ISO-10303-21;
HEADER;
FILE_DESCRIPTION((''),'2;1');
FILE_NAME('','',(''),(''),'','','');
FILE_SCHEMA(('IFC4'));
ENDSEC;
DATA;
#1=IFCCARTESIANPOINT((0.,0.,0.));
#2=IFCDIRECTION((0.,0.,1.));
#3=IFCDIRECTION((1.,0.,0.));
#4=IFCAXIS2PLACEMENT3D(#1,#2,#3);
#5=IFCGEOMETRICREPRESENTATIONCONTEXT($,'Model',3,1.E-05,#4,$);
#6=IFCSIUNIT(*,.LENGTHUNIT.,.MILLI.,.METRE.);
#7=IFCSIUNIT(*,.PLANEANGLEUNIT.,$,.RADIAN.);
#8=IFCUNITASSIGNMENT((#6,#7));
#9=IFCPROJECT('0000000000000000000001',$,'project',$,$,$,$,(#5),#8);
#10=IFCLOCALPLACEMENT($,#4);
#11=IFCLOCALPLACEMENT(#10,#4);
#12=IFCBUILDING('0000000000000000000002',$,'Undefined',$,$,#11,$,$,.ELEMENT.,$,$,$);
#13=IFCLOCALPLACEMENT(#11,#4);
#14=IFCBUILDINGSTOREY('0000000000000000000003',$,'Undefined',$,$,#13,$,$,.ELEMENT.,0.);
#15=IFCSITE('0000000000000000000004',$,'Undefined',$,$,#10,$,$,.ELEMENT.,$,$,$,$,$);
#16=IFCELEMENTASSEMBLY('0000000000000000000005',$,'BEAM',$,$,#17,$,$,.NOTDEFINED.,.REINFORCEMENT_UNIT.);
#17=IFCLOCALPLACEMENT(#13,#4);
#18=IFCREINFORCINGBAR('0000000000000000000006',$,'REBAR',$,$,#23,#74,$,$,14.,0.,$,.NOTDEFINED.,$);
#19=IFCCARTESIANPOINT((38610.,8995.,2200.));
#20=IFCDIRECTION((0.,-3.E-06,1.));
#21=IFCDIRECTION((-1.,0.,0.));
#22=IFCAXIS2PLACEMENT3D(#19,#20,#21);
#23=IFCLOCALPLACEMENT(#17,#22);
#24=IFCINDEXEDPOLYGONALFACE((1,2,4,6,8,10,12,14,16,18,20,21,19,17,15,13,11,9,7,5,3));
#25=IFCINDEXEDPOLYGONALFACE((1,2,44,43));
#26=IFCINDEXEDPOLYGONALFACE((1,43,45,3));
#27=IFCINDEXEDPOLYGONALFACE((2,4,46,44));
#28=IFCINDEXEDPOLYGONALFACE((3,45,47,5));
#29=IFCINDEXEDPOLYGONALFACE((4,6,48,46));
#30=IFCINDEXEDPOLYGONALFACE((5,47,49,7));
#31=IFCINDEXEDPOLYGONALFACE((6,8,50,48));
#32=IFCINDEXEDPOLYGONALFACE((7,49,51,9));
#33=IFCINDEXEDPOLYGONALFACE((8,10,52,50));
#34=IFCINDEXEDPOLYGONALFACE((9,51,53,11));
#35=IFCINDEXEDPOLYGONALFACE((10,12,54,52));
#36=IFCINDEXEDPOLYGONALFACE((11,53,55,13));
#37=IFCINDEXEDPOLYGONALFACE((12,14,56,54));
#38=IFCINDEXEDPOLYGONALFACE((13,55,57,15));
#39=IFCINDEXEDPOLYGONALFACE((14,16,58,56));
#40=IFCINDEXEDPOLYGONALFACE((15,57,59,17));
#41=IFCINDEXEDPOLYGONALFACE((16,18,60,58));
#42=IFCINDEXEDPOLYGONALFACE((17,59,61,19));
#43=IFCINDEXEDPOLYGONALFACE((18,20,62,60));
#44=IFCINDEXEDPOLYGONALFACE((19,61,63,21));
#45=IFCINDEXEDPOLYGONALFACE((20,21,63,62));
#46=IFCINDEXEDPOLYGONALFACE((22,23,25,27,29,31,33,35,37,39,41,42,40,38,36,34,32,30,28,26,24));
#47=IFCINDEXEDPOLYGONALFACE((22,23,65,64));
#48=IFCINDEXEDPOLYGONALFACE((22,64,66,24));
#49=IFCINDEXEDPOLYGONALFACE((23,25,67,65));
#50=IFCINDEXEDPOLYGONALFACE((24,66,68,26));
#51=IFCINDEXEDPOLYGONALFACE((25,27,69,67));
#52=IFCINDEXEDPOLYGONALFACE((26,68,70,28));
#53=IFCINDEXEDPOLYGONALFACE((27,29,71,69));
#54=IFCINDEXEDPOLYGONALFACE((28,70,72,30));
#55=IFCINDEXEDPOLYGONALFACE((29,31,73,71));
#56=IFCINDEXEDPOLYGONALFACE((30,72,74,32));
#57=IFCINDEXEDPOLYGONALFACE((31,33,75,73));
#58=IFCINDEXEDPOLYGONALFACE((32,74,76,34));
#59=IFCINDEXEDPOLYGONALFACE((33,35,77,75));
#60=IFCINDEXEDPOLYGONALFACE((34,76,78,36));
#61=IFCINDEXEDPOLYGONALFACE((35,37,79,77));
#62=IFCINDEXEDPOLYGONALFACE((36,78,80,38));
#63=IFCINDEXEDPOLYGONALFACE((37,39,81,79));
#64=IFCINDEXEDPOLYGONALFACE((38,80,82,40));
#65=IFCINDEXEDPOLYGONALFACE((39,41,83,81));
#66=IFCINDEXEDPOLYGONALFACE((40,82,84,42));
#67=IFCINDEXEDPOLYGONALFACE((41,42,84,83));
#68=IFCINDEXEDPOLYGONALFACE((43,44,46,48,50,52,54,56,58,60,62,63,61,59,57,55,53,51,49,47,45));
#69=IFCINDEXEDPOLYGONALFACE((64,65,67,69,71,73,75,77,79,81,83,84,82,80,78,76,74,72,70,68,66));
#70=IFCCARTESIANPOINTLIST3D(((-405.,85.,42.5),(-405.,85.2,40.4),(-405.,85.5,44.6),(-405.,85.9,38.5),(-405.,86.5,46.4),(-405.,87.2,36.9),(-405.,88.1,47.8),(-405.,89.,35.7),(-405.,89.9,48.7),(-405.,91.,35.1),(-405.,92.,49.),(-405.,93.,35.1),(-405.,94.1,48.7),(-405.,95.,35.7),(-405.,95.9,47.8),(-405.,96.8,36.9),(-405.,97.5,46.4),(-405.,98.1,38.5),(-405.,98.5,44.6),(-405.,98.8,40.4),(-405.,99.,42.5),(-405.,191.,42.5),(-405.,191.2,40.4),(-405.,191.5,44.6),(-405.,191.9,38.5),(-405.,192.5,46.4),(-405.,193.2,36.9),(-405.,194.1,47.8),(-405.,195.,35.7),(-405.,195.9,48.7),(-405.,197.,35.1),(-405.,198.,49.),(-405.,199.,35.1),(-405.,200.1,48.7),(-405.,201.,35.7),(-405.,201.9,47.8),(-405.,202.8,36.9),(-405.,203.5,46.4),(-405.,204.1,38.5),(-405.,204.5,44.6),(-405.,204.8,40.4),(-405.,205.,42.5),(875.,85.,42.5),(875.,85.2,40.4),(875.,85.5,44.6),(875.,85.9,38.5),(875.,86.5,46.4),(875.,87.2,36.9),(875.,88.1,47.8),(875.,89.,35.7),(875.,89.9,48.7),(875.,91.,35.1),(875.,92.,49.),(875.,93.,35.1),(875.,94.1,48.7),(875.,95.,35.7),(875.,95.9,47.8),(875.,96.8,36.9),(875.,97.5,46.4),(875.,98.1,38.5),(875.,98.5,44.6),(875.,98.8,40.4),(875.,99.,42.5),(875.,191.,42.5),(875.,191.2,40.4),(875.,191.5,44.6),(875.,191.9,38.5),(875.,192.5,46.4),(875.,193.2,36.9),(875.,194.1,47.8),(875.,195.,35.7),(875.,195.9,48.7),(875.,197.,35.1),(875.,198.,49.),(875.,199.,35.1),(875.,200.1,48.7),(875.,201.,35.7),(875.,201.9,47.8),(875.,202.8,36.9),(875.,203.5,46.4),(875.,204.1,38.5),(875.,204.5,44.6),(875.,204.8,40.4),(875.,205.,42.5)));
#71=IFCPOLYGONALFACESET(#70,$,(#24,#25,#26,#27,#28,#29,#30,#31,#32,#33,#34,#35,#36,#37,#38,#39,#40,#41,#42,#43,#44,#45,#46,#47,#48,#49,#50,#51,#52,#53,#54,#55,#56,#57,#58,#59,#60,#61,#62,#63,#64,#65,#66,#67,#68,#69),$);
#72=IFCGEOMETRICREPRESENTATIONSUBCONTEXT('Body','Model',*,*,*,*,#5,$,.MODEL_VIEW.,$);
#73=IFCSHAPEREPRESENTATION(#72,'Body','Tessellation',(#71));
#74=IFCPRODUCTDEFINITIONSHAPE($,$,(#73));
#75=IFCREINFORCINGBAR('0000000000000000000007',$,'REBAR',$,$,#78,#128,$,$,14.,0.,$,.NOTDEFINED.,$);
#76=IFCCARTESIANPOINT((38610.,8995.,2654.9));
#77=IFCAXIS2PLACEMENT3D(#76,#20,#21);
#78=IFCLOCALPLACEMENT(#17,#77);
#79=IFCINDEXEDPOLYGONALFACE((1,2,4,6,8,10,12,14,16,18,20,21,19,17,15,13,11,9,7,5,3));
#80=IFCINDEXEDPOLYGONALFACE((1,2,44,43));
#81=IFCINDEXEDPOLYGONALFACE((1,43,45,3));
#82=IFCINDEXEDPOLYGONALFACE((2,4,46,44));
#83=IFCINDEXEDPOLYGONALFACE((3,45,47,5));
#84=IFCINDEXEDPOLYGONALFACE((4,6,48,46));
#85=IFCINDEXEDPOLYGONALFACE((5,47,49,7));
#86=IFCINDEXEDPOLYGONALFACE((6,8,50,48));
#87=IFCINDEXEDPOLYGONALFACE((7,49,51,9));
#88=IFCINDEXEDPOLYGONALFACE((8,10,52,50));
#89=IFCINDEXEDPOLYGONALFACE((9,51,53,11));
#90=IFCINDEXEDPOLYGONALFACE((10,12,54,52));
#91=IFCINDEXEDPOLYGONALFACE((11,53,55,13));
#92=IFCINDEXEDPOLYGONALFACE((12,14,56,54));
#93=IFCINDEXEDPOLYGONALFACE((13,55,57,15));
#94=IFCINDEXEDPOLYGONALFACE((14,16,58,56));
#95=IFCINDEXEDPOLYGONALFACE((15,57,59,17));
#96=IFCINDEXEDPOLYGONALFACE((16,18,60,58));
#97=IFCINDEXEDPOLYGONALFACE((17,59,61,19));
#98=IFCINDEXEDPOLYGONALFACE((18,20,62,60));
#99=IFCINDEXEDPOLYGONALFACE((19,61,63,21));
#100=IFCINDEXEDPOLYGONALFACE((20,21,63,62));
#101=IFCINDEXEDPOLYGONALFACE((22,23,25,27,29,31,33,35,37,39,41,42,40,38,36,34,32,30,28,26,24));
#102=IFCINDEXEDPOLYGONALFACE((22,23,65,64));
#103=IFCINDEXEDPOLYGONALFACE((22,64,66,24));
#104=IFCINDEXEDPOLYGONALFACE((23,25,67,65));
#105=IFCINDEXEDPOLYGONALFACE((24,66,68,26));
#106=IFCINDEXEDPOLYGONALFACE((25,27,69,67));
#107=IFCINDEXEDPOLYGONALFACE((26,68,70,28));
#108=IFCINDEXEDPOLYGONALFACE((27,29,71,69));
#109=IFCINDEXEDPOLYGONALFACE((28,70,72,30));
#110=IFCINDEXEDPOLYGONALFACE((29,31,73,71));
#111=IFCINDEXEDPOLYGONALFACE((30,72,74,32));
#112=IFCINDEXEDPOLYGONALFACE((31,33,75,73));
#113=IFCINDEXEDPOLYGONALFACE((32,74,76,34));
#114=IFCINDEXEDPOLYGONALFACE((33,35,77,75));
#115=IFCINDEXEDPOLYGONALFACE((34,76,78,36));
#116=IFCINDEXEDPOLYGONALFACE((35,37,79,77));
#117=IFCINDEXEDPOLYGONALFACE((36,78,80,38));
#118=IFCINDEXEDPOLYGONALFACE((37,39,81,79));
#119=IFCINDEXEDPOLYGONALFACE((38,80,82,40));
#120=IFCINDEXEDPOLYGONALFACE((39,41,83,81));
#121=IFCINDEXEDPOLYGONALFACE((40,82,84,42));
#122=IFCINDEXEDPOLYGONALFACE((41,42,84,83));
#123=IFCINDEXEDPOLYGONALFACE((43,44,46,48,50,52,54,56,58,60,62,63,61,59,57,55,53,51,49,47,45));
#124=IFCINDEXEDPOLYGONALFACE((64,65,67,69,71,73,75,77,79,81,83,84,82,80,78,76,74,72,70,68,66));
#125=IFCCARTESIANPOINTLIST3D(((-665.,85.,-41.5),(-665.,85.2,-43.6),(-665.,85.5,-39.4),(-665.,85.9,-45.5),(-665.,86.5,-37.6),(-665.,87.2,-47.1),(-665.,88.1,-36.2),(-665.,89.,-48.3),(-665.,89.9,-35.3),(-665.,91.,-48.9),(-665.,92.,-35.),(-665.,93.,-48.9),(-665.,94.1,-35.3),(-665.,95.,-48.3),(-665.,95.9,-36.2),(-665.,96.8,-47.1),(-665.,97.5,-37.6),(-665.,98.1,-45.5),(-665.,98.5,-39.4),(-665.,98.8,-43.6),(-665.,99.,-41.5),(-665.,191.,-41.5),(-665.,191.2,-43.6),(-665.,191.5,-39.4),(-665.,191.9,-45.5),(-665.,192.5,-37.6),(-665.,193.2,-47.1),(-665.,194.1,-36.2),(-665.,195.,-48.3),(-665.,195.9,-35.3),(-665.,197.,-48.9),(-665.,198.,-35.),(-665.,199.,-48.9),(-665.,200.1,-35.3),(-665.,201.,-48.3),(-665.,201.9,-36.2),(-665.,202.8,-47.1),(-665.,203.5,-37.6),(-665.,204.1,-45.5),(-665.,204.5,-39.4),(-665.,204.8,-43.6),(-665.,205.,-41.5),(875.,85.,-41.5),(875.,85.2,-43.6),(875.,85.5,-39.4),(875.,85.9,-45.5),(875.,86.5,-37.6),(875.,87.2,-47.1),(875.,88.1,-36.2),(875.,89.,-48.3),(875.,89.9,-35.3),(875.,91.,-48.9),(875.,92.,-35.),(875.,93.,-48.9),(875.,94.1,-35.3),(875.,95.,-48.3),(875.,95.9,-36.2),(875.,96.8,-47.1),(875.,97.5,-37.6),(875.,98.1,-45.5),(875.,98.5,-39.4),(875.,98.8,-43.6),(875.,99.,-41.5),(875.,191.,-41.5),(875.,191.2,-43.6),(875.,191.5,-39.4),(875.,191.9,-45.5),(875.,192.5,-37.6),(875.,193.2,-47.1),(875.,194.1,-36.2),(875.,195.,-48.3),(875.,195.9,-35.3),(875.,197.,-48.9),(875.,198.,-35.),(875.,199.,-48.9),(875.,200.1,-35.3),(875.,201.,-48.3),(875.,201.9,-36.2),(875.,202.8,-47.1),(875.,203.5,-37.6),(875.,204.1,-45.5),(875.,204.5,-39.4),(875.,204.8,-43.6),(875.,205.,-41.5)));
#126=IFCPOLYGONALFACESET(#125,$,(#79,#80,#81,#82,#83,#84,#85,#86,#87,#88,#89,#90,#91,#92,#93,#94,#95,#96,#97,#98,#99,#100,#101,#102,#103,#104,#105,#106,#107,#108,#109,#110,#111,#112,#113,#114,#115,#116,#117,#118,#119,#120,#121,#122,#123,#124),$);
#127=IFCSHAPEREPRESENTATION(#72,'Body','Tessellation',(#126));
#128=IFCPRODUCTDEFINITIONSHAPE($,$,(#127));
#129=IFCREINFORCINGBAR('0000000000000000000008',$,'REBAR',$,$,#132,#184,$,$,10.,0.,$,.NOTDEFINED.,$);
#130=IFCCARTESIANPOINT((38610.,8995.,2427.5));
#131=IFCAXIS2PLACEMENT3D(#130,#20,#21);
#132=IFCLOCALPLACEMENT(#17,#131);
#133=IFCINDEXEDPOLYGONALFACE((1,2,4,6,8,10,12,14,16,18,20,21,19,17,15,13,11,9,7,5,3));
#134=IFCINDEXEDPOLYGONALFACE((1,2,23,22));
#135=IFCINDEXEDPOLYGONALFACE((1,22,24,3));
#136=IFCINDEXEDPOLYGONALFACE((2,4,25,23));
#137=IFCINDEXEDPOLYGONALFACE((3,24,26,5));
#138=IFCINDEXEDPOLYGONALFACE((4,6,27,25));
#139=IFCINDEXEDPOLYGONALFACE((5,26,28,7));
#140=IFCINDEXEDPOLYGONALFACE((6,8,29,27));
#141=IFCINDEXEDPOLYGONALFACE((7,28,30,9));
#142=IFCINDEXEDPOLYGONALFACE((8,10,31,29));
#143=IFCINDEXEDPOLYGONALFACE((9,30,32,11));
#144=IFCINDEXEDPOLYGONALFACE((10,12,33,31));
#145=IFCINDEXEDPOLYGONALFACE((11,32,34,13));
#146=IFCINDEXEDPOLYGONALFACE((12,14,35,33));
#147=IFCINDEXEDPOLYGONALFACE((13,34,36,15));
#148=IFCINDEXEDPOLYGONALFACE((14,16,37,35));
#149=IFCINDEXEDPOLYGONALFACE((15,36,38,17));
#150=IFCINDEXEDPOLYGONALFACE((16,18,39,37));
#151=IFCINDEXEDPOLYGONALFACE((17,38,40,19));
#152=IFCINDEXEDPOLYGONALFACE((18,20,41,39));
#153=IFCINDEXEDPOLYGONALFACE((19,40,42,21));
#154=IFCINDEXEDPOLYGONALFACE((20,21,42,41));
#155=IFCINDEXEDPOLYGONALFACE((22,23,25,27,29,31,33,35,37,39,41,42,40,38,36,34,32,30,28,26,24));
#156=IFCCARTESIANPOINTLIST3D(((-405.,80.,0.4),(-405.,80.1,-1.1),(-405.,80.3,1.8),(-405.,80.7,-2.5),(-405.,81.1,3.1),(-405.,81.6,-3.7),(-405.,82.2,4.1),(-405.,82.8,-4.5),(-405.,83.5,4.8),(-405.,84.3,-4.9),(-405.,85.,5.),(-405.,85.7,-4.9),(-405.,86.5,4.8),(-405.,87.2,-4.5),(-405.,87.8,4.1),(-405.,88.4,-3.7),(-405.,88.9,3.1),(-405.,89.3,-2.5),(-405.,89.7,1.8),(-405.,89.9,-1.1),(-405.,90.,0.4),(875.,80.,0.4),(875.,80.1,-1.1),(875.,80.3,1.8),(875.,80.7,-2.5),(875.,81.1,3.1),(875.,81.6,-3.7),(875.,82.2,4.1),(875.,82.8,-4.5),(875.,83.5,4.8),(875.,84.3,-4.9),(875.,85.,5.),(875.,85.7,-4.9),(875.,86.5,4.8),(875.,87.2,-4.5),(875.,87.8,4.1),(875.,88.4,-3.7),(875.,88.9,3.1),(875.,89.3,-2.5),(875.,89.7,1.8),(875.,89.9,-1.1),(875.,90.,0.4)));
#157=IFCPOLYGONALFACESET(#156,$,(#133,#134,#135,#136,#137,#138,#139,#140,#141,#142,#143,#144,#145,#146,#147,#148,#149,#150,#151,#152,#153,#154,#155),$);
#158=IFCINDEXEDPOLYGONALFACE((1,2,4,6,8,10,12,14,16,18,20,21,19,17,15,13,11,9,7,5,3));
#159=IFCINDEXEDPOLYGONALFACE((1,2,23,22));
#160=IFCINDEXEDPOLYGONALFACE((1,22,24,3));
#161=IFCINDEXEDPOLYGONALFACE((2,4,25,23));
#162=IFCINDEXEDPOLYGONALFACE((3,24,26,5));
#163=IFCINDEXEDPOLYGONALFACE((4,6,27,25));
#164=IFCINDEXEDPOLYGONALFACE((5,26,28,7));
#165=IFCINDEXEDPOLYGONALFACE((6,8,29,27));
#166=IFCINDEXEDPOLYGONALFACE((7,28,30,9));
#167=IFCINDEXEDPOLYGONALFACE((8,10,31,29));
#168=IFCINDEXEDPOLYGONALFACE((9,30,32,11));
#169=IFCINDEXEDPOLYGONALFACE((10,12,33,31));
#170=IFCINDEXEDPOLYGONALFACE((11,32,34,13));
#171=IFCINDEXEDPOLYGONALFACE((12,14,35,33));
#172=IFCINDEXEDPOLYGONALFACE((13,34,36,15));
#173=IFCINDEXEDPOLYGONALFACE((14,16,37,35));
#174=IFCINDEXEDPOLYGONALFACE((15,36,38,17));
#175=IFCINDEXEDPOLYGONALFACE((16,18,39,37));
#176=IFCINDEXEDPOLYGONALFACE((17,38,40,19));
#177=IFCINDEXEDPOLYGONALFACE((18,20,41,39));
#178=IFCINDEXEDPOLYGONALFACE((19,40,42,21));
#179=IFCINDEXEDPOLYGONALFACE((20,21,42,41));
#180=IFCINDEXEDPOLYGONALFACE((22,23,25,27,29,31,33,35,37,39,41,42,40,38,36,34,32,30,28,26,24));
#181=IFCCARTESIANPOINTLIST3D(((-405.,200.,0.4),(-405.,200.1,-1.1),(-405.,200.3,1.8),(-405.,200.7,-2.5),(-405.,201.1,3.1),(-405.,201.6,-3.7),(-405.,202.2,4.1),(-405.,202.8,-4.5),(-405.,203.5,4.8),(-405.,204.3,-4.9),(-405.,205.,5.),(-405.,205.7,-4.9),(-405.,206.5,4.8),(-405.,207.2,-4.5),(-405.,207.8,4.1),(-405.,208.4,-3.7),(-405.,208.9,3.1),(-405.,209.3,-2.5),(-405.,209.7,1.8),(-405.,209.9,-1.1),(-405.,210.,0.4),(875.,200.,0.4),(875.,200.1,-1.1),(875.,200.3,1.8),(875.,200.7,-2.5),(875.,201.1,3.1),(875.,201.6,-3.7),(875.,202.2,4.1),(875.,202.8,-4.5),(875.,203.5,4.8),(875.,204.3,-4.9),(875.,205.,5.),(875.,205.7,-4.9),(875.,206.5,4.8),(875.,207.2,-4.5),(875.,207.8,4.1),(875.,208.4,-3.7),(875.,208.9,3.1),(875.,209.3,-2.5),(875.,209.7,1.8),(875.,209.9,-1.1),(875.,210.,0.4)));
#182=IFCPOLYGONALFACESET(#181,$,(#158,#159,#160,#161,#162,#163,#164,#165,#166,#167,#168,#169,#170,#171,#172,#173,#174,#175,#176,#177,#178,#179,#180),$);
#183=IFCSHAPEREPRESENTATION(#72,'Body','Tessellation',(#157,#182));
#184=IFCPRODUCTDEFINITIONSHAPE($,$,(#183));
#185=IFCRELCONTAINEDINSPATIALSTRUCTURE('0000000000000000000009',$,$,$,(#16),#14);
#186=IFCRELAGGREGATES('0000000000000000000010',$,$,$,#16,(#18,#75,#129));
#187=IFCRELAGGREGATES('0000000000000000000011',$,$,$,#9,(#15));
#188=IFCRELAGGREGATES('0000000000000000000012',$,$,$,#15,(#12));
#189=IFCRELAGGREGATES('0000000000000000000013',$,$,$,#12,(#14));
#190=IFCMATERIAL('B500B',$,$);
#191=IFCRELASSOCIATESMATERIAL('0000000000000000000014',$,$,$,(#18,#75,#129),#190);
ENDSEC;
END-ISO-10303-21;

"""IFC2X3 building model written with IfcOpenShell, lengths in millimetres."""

from ifc_helpers import new_model, entity, si_unit, frame, origin_with_axes, place, context, subcontext, project, spatial, source, transform, mapped, material, element, aggregate, save


model = new_model("IFC2X3")

# Units and contexts
model_context = context("Model", 3, precision=1e-05, world=origin_with_axes())
body_context = subcontext(model_context, "Body", "Model", "MODEL_VIEW")
ifc_project = project(units=[si_unit("LENGTHUNIT", "METRE", prefix="MILLI"), si_unit("PLANEANGLEUNIT", "RADIAN")], contexts=[model_context])

# Site, building, storey
site_placement = place(None, origin_with_axes())
site = spatial("IfcSite", under=ifc_project, at=site_placement, Name="Undefined", CompositionType="ELEMENT")
building_placement = place(site_placement, origin_with_axes())
building = spatial("IfcBuilding", under=site, at=building_placement, Name="Undefined", CompositionType="ELEMENT")
storey_placement = place(building_placement, origin_with_axes())
storey = spatial("IfcBuildingStorey", under=building, at=storey_placement, Name="Undefined", CompositionType="ELEMENT", Elevation=0.0)

# Shared definitions
ifc_material_1 = material(Name="B500B")

# Element assembly, reinforcing bars
assembly_1_placement = place(storey_placement, origin_with_axes())
assembly_1 = element("IfcElementAssembly", 1, at=assembly_1_placement, inside=storey, Name="BEAM", AssemblyPlace="NOTDEFINED", PredefinedType="REINFORCEMENT_UNIT")
shared_shape_1 = source(origin_with_axes(), body_context, "Body", "AdvancedSweptSolid", [
    entity("IfcSweptDiskSolid", entity("IfcTrimmedCurve", entity("IfcLine", entity("IfcCartesianPoint", [0.0, 0.0, 0.0]), entity("IfcVector", entity("IfcDirection", [1.0, 0.0, 0.0]), 1.0)), [entity("IfcParameterValue", 0.0)], [entity("IfcParameterValue", 1279.989613)], True, "PARAMETER"), 7.0, None, 0.0, 1280.0),
])
shared_shape_2 = source(origin_with_axes(), body_context, "Body", "AdvancedSweptSolid", [
    entity("IfcSweptDiskSolid", entity("IfcTrimmedCurve", entity("IfcLine", entity("IfcCartesianPoint", [0.0, 0.0, 0.0]), entity("IfcVector", entity("IfcDirection", [1.0, 0.0, 0.0]), 1.0)), [entity("IfcParameterValue", 0.0)], [entity("IfcParameterValue", 1279.989613)], True, "PARAMETER"), 7.0, None, 0.0, 1280.0),
])
reinforcing_bar_1_placement = place(assembly_1_placement, frame((38610.0, 8995.0, 2200.0), z_axis=(0.0, -0.000003, 1.0), x_axis=(-1.0, 0.0, 0.0)))
reinforcing_bar_1 = element("IfcReinforcingBar", 2, at=reinforcing_bar_1_placement, material=ifc_material_1, Name="REBAR", BarRole="NOTDEFINED", CrossSectionArea=0.0, NominalDiameter=14.0, context=body_context, shape_type="MappedRepresentation", body=[
    mapped(shared_shape_1, transform((-405.0, 92.0, 42.0))),
    mapped(shared_shape_2, transform((-405.0, 198.0, 42.0))),
])
shared_shape_3 = source(origin_with_axes(), body_context, "Body", "AdvancedSweptSolid", [
    entity("IfcSweptDiskSolid", entity("IfcTrimmedCurve", entity("IfcLine", entity("IfcCartesianPoint", [0.0, 0.0, 0.0]), entity("IfcVector", entity("IfcDirection", [1.0, 0.0, 0.0]), 1.0)), [entity("IfcParameterValue", 0.0)], [entity("IfcParameterValue", 1539.989613)], True, "PARAMETER"), 7.0, None, 0.0, 1540.0),
])
shared_shape_4 = source(origin_with_axes(), body_context, "Body", "AdvancedSweptSolid", [
    entity("IfcSweptDiskSolid", entity("IfcTrimmedCurve", entity("IfcLine", entity("IfcCartesianPoint", [0.0, 0.0, 0.0]), entity("IfcVector", entity("IfcDirection", [1.0, 0.0, 0.0]), 1.0)), [entity("IfcParameterValue", 0.0)], [entity("IfcParameterValue", 1539.989613)], True, "PARAMETER"), 7.0, None, 0.0, 1540.0),
])
reinforcing_bar_2_placement = place(assembly_1_placement, frame((38610.0, 8995.0, 2654.9), z_axis=(0.0, -0.000003, 1.0), x_axis=(-1.0, 0.0, 0.0)))
reinforcing_bar_2 = element("IfcReinforcingBar", 3, at=reinforcing_bar_2_placement, material=ifc_material_1, Name="REBAR", BarRole="NOTDEFINED", CrossSectionArea=0.0, NominalDiameter=14.0, context=body_context, shape_type="MappedRepresentation", body=[
    mapped(shared_shape_3, transform((-665.0, 92.0, -42.0))),
    mapped(shared_shape_4, transform((-665.0, 198.0, -42.0))),
])
shared_shape_5 = source(origin_with_axes(), body_context, "Body", "AdvancedSweptSolid", [
    entity("IfcSweptDiskSolid", entity("IfcTrimmedCurve", entity("IfcLine", entity("IfcCartesianPoint", [0.0, 0.0, 0.0]), entity("IfcVector", entity("IfcDirection", [1.0, 0.0, 0.0]), 1.0)), [entity("IfcParameterValue", 0.0)], [entity("IfcParameterValue", 1279.989613)], True, "PARAMETER"), 5.0, None, 0.0, 1280.0),
])
shared_shape_6 = source(origin_with_axes(), body_context, "Body", "AdvancedSweptSolid", [
    entity("IfcSweptDiskSolid", entity("IfcTrimmedCurve", entity("IfcLine", entity("IfcCartesianPoint", [0.0, 0.0, 0.0]), entity("IfcVector", entity("IfcDirection", [1.0, 0.0, 0.0]), 1.0)), [entity("IfcParameterValue", 0.0)], [entity("IfcParameterValue", 1279.989613)], True, "PARAMETER"), 5.0, None, 0.0, 1280.0),
])
reinforcing_bar_3_placement = place(assembly_1_placement, frame((38610.0, 8995.0, 2427.5), z_axis=(0.0, -0.000003, 1.0), x_axis=(-1.0, 0.0, 0.0)))
reinforcing_bar_3 = element("IfcReinforcingBar", 4, at=reinforcing_bar_3_placement, material=ifc_material_1, Name="REBAR", BarRole="NOTDEFINED", CrossSectionArea=0.0, NominalDiameter=10.0, context=body_context, shape_type="MappedRepresentation", body=[
    mapped(shared_shape_5, transform((-405.0, 85.0, 0.0))),
    mapped(shared_shape_6, transform((-405.0, 205.0, 0.0))),
])
aggregate(assembly_1, [reinforcing_bar_1, reinforcing_bar_2, reinforcing_bar_3])

save(model, "model.ifc")
